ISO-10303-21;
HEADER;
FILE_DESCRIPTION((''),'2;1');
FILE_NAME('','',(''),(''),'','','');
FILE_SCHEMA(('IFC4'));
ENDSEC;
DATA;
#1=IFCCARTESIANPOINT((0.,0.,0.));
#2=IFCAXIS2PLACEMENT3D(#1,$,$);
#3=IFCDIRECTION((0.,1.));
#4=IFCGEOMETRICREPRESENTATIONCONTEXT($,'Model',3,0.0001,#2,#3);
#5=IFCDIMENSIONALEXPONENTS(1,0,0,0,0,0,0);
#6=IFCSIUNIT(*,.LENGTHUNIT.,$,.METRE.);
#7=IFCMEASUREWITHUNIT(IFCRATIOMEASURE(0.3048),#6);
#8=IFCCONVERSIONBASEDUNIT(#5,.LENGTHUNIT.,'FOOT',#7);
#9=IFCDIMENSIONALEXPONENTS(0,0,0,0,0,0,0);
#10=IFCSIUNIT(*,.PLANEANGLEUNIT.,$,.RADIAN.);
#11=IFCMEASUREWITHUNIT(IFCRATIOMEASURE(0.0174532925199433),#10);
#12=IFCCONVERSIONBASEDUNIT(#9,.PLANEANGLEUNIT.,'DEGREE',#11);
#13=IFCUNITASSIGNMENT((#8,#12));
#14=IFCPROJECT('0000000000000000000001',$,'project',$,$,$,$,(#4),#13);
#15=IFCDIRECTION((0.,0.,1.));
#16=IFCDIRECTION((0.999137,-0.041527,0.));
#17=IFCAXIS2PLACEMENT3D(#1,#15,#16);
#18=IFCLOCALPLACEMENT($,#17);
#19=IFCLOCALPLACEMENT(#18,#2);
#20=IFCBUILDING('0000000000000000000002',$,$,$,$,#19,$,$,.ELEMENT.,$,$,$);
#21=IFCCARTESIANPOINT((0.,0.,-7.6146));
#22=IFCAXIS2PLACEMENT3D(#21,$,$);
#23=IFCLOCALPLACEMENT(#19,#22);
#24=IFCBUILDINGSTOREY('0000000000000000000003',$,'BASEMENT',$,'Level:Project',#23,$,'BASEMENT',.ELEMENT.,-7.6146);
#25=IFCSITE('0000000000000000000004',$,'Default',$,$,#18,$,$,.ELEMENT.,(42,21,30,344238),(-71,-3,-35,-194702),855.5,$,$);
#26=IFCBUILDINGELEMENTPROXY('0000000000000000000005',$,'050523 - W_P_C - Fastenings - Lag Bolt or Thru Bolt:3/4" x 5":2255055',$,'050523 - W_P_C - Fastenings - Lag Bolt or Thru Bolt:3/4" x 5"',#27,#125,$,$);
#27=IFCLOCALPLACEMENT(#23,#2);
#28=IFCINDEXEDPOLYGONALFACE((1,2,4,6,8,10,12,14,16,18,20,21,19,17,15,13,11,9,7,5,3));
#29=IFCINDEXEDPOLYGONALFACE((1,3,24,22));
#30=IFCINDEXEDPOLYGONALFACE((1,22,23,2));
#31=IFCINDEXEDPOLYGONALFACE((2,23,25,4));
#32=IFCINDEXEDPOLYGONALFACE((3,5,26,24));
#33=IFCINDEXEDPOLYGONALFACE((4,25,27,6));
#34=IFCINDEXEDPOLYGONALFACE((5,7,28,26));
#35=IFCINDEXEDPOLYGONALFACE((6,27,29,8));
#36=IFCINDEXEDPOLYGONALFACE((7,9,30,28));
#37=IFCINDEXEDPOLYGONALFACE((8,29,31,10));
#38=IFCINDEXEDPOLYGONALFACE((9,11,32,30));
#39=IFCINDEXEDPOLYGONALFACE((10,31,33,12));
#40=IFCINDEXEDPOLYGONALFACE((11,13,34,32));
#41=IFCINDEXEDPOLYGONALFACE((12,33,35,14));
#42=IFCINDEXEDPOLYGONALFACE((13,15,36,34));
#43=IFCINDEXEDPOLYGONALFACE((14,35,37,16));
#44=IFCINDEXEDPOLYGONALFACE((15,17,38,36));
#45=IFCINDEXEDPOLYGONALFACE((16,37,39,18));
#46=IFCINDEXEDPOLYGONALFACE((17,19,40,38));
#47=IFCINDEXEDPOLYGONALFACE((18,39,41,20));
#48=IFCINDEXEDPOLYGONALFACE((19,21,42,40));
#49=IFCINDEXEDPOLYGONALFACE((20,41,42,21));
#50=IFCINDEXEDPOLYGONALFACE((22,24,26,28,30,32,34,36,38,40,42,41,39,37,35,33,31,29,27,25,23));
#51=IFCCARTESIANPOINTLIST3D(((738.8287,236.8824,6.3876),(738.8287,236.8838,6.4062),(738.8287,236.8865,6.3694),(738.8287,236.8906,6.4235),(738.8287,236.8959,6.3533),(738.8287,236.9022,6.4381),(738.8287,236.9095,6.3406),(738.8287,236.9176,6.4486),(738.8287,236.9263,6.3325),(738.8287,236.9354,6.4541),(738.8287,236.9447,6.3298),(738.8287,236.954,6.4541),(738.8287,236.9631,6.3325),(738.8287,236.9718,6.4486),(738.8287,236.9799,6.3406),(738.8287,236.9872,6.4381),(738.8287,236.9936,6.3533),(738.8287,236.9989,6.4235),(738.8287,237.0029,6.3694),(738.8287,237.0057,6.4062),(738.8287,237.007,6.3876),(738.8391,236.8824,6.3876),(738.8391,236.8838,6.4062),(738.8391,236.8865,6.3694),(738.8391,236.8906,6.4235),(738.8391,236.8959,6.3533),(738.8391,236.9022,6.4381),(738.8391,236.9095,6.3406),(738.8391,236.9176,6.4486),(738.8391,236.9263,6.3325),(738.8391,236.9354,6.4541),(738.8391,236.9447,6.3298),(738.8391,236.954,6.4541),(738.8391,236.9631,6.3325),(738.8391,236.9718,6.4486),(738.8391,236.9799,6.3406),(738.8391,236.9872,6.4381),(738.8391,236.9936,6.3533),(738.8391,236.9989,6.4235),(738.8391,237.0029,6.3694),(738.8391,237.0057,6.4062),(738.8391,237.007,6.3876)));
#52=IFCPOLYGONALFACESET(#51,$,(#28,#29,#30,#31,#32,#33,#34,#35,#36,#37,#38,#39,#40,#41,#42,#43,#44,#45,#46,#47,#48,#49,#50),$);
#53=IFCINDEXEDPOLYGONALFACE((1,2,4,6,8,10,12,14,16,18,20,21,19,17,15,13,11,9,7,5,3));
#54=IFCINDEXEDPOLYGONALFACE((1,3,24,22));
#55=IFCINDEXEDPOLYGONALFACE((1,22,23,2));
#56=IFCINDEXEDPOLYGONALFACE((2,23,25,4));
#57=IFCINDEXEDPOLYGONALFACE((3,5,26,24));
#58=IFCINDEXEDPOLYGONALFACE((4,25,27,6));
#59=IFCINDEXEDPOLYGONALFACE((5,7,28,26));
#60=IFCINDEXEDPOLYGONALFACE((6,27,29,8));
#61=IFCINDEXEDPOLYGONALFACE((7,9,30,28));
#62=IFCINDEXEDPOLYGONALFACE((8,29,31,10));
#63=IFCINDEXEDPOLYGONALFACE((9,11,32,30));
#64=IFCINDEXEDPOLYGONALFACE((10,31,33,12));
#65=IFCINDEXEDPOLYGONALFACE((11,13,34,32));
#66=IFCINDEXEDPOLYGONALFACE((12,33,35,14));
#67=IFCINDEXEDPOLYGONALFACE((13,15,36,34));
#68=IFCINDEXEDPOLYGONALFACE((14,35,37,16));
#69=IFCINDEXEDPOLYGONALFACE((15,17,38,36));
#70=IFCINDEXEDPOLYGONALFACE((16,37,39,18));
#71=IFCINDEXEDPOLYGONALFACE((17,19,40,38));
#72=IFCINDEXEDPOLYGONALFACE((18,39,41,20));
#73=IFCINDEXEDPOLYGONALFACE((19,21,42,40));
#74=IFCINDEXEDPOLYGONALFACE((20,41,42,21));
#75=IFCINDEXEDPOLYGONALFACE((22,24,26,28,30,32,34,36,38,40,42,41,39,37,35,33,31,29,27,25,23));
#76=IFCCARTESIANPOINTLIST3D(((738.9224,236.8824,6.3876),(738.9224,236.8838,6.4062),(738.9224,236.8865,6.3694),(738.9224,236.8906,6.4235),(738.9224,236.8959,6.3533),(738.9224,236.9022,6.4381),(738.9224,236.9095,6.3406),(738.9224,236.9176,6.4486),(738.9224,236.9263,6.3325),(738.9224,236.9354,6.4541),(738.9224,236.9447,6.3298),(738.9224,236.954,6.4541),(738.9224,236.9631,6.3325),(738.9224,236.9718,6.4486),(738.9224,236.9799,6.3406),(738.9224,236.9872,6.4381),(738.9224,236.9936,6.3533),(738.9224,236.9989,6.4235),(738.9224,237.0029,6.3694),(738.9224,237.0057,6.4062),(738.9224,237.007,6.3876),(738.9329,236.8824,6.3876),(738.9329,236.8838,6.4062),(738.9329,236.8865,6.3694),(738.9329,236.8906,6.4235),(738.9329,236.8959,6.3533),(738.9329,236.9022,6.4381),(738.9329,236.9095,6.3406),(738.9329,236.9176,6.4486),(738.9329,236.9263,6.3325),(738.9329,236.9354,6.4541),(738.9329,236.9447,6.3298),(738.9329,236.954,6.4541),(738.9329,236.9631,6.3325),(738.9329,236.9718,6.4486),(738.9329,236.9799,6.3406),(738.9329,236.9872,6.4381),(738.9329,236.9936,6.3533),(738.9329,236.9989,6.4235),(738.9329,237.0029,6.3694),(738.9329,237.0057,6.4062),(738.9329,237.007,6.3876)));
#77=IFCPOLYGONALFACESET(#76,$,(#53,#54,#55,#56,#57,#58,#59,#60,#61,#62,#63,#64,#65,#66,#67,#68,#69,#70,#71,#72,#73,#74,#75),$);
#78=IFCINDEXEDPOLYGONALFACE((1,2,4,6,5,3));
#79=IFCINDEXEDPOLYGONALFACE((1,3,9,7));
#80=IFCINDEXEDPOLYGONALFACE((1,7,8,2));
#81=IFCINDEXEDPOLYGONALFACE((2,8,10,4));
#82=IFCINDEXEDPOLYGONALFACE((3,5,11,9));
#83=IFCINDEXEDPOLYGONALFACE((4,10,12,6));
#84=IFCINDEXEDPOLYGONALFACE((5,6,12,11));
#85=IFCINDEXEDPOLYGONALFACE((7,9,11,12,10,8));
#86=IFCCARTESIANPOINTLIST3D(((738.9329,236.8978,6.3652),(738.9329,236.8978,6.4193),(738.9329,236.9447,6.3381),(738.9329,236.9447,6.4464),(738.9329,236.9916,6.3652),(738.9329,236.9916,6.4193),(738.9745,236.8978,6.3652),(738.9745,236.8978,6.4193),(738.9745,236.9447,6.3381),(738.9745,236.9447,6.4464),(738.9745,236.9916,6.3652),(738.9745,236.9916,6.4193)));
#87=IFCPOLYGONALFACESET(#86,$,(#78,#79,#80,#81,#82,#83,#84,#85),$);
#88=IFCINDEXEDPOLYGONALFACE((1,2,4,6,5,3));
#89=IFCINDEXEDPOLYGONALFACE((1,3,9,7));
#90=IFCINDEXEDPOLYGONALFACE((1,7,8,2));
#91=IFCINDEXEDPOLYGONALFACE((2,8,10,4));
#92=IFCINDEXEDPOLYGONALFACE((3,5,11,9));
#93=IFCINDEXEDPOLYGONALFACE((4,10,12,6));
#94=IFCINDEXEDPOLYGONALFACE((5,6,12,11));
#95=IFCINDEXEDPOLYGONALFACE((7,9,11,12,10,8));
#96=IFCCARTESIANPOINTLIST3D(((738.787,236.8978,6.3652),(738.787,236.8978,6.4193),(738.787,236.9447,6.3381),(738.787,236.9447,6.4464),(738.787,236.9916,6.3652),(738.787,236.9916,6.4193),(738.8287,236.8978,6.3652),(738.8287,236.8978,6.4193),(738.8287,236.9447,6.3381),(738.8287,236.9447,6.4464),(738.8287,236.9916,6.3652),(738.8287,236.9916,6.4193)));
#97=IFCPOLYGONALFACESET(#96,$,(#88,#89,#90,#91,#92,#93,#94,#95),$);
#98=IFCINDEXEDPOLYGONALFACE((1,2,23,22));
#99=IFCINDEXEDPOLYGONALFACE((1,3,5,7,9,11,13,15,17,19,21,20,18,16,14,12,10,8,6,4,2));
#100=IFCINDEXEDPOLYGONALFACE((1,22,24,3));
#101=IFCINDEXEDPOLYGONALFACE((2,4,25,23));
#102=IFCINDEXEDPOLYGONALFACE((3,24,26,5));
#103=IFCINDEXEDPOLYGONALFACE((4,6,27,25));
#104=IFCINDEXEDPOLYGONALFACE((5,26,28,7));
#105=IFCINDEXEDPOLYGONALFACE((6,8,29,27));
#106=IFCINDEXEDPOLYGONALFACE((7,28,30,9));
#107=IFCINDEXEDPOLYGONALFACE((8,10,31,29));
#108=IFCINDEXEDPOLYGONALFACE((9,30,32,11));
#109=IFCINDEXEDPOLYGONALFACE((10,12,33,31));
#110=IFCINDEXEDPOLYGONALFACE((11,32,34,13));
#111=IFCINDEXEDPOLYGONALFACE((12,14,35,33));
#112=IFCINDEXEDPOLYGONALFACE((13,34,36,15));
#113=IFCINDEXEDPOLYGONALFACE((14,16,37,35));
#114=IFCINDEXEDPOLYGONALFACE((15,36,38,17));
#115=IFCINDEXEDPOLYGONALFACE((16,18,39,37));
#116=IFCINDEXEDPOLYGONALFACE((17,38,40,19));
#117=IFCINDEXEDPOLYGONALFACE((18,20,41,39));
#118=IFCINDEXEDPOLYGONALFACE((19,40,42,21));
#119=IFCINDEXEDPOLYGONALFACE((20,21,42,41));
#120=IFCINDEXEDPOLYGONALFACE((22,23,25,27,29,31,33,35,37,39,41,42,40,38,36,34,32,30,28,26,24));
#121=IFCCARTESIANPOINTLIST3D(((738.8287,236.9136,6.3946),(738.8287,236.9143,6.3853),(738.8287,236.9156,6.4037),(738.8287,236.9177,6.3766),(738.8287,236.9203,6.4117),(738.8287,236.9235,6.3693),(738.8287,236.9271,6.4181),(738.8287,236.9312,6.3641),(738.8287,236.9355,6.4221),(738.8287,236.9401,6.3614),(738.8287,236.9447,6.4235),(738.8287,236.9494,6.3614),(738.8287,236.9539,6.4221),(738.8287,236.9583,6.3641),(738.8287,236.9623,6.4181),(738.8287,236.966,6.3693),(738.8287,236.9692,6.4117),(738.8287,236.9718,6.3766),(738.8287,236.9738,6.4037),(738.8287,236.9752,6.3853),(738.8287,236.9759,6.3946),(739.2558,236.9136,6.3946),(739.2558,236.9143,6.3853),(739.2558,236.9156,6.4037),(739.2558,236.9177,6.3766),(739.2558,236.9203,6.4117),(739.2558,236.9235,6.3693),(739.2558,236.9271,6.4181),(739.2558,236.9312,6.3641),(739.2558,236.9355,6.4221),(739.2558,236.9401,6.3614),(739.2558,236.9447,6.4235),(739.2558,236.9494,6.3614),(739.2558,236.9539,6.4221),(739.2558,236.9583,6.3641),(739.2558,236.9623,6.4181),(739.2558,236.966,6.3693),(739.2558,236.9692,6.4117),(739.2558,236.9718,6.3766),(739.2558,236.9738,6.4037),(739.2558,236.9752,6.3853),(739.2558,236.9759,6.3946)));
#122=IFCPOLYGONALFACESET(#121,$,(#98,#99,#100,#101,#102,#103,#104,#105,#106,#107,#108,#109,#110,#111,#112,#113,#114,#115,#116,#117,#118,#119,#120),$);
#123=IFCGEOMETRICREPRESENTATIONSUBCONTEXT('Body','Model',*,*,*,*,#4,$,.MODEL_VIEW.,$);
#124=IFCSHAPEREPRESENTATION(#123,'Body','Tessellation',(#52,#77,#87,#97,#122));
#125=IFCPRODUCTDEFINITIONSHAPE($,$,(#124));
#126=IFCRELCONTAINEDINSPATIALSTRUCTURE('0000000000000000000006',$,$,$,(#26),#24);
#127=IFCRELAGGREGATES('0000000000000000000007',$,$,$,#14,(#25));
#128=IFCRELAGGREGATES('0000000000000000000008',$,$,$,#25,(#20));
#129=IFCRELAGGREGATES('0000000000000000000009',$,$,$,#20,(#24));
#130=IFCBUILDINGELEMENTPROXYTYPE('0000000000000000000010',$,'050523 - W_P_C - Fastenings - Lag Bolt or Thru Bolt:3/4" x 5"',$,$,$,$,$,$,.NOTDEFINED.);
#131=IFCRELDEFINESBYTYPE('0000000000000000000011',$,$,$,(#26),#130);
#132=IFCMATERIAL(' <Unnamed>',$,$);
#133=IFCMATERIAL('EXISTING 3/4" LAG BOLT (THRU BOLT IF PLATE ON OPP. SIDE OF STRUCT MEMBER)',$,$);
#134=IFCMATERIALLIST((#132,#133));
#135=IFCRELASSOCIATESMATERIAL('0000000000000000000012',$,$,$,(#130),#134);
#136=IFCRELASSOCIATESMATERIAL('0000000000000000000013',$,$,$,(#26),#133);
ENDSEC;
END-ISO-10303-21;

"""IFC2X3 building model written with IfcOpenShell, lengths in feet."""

from ifc_helpers import new_model, entity, si_unit, converted_unit, direction, frame, frame_2d, origin, place, context, subcontext, project, spatial, polyline, circle, outline, extrude, source, transform, mapped, material, material_list, type_object, type_shapes, element, save


model = new_model("IFC2X3")

# Units and contexts
model_context = context("Model", 3, precision=0.0001, world=origin(), true_north=direction((0.0, 1.0)))
body_context = subcontext(model_context, "Body", "Model", "MODEL_VIEW")
ifc_project = project(units=[converted_unit("LENGTHUNIT", "FOOT", entity("IfcRatioMeasure", 0.3048), si_unit("LENGTHUNIT", "METRE"), dimensions=[1, 0, 0, 0, 0, 0, 0]), converted_unit("PLANEANGLEUNIT", "DEGREE", entity("IfcRatioMeasure", 0.0174532925199433), si_unit("PLANEANGLEUNIT", "RADIAN"), dimensions=[0, 0, 0, 0, 0, 0, 0])], contexts=[model_context])

# Site, building, storey
site_placement = place(None, frame((0.0, 0.0, 0.0), z_axis=(0.0, 0.0, 1.0), x_axis=(0.999137, -0.041527, 0.0)))
site = spatial("IfcSite", under=ifc_project, at=site_placement, Name="Default", CompositionType="ELEMENT", RefLatitude=(42, 21, 30, 344238), RefLongitude=(-71, -3, -35, -194702), RefElevation=855.5)
building_placement = place(site_placement, origin())
building = spatial("IfcBuilding", under=site, at=building_placement, CompositionType="ELEMENT")
storey_placement = place(building_placement, frame((0.0, 0.0, -7.6146)))
storey = spatial("IfcBuildingStorey", under=building, at=storey_placement, Name="BASEMENT", ObjectType="Level:Project", LongName="BASEMENT", CompositionType="ELEMENT", Elevation=-7.6146)

# Building element proxy
ifc_material_1 = material(Name="EXISTING 3/4\" LAG BOLT (THRU BOLT IF PLATE ON OPP. SIDE OF STRUCT MEMBER)")
ifc_material_2 = material(Name=" <Unnamed>")
ifc_material_list_1 = material_list([ifc_material_2, ifc_material_1])
building_element_proxy_type_1 = type_object("IfcBuildingElementProxyType", Name="050523 - W_P_C - Fastenings - Lag Bolt or Thru Bolt:3/4\" x 5\"", PredefinedType="NOTDEFINED", material=ifc_material_list_1)
shared_shape_1 = source(origin(), body_context, "Body", "SweptSolid", [
    extrude(circle(Radius=0.0625, at=frame_2d((0.0, 0.0), x_axis=(1.0, 0.0))), frame((0.0, 0.0, 0.0), z_axis=(0.0, 0.0, 1.0), x_axis=(0.0, -1.0, 0.0)), (0.0, 0.0, 1.0), 0.0104),
    extrude(circle(Radius=0.0625, at=frame_2d((0.0, 0.0), x_axis=(1.0, 0.0))), frame((0.0, 0.0, -0.0938), z_axis=(0.0, 0.0, 1.0), x_axis=(0.0, -1.0, 0.0)), (0.0, 0.0, 1.0), 0.0104),
    extrude(outline(polyline([(-0.0271, -0.0469), (0.0271, -0.0469), (0.0541, 0.0), (0.0271, 0.0469), (-0.0271, 0.0469), (-0.0541, 0.0), (-0.0271, -0.0469)])), frame((0.0, 0.0, -0.1354), z_axis=(0.0, 0.0, 1.0), x_axis=(0.866025, -0.5, 0.0)), (0.0, 0.0, 1.0), 0.0417),
    extrude(outline(polyline([(-0.0271, -0.0469), (0.0271, -0.0469), (0.0541, 0.0), (0.0271, 0.0469), (-0.0271, 0.0469), (-0.0541, 0.0), (-0.0271, -0.0469)])), frame((0.0, 0.0, 0.0104), z_axis=(0.0, 0.0, 1.0), x_axis=(0.0, -1.0, 0.0)), (0.0, 0.0, 1.0), 0.0417),
    extrude(circle(Radius=0.0312, at=frame_2d((0.0, 0.0), x_axis=(1.0, 0.0))), frame((0.0, 0.0, -0.4167), z_axis=(0.0, 0.0, 1.0), x_axis=(0.0, 1.0, 0.0)), (0.0, 0.0, 1.0), 0.4271),
])
type_shapes(building_element_proxy_type_1, [shared_shape_1])
for number, where, z_axis, x_axis, name in (
    (1, (738.8391, 236.9447, 6.3923), (-1.0, 0.0, 0.0), (0.0, -1.0, 0.0), "050523 - W_P_C - Fastenings - Lag Bolt or Thru Bolt:3/4\" x 5\":2255055"),
):
    element("IfcBuildingElementProxy", number, at=place(storey_placement, frame(where, z_axis=z_axis, x_axis=x_axis)), inside=storey, type_object=building_element_proxy_type_1, material=ifc_material_1, Name=name, ObjectType="050523 - W_P_C - Fastenings - Lag Bolt or Thru Bolt:3/4\" x 5\"", context=body_context, shape_type="MappedRepresentation", body=[
        mapped(shared_shape_1, transform((0.0, 0.0, 0.0), scale=1.0)),
    ])

save(model, "model.ifc")
